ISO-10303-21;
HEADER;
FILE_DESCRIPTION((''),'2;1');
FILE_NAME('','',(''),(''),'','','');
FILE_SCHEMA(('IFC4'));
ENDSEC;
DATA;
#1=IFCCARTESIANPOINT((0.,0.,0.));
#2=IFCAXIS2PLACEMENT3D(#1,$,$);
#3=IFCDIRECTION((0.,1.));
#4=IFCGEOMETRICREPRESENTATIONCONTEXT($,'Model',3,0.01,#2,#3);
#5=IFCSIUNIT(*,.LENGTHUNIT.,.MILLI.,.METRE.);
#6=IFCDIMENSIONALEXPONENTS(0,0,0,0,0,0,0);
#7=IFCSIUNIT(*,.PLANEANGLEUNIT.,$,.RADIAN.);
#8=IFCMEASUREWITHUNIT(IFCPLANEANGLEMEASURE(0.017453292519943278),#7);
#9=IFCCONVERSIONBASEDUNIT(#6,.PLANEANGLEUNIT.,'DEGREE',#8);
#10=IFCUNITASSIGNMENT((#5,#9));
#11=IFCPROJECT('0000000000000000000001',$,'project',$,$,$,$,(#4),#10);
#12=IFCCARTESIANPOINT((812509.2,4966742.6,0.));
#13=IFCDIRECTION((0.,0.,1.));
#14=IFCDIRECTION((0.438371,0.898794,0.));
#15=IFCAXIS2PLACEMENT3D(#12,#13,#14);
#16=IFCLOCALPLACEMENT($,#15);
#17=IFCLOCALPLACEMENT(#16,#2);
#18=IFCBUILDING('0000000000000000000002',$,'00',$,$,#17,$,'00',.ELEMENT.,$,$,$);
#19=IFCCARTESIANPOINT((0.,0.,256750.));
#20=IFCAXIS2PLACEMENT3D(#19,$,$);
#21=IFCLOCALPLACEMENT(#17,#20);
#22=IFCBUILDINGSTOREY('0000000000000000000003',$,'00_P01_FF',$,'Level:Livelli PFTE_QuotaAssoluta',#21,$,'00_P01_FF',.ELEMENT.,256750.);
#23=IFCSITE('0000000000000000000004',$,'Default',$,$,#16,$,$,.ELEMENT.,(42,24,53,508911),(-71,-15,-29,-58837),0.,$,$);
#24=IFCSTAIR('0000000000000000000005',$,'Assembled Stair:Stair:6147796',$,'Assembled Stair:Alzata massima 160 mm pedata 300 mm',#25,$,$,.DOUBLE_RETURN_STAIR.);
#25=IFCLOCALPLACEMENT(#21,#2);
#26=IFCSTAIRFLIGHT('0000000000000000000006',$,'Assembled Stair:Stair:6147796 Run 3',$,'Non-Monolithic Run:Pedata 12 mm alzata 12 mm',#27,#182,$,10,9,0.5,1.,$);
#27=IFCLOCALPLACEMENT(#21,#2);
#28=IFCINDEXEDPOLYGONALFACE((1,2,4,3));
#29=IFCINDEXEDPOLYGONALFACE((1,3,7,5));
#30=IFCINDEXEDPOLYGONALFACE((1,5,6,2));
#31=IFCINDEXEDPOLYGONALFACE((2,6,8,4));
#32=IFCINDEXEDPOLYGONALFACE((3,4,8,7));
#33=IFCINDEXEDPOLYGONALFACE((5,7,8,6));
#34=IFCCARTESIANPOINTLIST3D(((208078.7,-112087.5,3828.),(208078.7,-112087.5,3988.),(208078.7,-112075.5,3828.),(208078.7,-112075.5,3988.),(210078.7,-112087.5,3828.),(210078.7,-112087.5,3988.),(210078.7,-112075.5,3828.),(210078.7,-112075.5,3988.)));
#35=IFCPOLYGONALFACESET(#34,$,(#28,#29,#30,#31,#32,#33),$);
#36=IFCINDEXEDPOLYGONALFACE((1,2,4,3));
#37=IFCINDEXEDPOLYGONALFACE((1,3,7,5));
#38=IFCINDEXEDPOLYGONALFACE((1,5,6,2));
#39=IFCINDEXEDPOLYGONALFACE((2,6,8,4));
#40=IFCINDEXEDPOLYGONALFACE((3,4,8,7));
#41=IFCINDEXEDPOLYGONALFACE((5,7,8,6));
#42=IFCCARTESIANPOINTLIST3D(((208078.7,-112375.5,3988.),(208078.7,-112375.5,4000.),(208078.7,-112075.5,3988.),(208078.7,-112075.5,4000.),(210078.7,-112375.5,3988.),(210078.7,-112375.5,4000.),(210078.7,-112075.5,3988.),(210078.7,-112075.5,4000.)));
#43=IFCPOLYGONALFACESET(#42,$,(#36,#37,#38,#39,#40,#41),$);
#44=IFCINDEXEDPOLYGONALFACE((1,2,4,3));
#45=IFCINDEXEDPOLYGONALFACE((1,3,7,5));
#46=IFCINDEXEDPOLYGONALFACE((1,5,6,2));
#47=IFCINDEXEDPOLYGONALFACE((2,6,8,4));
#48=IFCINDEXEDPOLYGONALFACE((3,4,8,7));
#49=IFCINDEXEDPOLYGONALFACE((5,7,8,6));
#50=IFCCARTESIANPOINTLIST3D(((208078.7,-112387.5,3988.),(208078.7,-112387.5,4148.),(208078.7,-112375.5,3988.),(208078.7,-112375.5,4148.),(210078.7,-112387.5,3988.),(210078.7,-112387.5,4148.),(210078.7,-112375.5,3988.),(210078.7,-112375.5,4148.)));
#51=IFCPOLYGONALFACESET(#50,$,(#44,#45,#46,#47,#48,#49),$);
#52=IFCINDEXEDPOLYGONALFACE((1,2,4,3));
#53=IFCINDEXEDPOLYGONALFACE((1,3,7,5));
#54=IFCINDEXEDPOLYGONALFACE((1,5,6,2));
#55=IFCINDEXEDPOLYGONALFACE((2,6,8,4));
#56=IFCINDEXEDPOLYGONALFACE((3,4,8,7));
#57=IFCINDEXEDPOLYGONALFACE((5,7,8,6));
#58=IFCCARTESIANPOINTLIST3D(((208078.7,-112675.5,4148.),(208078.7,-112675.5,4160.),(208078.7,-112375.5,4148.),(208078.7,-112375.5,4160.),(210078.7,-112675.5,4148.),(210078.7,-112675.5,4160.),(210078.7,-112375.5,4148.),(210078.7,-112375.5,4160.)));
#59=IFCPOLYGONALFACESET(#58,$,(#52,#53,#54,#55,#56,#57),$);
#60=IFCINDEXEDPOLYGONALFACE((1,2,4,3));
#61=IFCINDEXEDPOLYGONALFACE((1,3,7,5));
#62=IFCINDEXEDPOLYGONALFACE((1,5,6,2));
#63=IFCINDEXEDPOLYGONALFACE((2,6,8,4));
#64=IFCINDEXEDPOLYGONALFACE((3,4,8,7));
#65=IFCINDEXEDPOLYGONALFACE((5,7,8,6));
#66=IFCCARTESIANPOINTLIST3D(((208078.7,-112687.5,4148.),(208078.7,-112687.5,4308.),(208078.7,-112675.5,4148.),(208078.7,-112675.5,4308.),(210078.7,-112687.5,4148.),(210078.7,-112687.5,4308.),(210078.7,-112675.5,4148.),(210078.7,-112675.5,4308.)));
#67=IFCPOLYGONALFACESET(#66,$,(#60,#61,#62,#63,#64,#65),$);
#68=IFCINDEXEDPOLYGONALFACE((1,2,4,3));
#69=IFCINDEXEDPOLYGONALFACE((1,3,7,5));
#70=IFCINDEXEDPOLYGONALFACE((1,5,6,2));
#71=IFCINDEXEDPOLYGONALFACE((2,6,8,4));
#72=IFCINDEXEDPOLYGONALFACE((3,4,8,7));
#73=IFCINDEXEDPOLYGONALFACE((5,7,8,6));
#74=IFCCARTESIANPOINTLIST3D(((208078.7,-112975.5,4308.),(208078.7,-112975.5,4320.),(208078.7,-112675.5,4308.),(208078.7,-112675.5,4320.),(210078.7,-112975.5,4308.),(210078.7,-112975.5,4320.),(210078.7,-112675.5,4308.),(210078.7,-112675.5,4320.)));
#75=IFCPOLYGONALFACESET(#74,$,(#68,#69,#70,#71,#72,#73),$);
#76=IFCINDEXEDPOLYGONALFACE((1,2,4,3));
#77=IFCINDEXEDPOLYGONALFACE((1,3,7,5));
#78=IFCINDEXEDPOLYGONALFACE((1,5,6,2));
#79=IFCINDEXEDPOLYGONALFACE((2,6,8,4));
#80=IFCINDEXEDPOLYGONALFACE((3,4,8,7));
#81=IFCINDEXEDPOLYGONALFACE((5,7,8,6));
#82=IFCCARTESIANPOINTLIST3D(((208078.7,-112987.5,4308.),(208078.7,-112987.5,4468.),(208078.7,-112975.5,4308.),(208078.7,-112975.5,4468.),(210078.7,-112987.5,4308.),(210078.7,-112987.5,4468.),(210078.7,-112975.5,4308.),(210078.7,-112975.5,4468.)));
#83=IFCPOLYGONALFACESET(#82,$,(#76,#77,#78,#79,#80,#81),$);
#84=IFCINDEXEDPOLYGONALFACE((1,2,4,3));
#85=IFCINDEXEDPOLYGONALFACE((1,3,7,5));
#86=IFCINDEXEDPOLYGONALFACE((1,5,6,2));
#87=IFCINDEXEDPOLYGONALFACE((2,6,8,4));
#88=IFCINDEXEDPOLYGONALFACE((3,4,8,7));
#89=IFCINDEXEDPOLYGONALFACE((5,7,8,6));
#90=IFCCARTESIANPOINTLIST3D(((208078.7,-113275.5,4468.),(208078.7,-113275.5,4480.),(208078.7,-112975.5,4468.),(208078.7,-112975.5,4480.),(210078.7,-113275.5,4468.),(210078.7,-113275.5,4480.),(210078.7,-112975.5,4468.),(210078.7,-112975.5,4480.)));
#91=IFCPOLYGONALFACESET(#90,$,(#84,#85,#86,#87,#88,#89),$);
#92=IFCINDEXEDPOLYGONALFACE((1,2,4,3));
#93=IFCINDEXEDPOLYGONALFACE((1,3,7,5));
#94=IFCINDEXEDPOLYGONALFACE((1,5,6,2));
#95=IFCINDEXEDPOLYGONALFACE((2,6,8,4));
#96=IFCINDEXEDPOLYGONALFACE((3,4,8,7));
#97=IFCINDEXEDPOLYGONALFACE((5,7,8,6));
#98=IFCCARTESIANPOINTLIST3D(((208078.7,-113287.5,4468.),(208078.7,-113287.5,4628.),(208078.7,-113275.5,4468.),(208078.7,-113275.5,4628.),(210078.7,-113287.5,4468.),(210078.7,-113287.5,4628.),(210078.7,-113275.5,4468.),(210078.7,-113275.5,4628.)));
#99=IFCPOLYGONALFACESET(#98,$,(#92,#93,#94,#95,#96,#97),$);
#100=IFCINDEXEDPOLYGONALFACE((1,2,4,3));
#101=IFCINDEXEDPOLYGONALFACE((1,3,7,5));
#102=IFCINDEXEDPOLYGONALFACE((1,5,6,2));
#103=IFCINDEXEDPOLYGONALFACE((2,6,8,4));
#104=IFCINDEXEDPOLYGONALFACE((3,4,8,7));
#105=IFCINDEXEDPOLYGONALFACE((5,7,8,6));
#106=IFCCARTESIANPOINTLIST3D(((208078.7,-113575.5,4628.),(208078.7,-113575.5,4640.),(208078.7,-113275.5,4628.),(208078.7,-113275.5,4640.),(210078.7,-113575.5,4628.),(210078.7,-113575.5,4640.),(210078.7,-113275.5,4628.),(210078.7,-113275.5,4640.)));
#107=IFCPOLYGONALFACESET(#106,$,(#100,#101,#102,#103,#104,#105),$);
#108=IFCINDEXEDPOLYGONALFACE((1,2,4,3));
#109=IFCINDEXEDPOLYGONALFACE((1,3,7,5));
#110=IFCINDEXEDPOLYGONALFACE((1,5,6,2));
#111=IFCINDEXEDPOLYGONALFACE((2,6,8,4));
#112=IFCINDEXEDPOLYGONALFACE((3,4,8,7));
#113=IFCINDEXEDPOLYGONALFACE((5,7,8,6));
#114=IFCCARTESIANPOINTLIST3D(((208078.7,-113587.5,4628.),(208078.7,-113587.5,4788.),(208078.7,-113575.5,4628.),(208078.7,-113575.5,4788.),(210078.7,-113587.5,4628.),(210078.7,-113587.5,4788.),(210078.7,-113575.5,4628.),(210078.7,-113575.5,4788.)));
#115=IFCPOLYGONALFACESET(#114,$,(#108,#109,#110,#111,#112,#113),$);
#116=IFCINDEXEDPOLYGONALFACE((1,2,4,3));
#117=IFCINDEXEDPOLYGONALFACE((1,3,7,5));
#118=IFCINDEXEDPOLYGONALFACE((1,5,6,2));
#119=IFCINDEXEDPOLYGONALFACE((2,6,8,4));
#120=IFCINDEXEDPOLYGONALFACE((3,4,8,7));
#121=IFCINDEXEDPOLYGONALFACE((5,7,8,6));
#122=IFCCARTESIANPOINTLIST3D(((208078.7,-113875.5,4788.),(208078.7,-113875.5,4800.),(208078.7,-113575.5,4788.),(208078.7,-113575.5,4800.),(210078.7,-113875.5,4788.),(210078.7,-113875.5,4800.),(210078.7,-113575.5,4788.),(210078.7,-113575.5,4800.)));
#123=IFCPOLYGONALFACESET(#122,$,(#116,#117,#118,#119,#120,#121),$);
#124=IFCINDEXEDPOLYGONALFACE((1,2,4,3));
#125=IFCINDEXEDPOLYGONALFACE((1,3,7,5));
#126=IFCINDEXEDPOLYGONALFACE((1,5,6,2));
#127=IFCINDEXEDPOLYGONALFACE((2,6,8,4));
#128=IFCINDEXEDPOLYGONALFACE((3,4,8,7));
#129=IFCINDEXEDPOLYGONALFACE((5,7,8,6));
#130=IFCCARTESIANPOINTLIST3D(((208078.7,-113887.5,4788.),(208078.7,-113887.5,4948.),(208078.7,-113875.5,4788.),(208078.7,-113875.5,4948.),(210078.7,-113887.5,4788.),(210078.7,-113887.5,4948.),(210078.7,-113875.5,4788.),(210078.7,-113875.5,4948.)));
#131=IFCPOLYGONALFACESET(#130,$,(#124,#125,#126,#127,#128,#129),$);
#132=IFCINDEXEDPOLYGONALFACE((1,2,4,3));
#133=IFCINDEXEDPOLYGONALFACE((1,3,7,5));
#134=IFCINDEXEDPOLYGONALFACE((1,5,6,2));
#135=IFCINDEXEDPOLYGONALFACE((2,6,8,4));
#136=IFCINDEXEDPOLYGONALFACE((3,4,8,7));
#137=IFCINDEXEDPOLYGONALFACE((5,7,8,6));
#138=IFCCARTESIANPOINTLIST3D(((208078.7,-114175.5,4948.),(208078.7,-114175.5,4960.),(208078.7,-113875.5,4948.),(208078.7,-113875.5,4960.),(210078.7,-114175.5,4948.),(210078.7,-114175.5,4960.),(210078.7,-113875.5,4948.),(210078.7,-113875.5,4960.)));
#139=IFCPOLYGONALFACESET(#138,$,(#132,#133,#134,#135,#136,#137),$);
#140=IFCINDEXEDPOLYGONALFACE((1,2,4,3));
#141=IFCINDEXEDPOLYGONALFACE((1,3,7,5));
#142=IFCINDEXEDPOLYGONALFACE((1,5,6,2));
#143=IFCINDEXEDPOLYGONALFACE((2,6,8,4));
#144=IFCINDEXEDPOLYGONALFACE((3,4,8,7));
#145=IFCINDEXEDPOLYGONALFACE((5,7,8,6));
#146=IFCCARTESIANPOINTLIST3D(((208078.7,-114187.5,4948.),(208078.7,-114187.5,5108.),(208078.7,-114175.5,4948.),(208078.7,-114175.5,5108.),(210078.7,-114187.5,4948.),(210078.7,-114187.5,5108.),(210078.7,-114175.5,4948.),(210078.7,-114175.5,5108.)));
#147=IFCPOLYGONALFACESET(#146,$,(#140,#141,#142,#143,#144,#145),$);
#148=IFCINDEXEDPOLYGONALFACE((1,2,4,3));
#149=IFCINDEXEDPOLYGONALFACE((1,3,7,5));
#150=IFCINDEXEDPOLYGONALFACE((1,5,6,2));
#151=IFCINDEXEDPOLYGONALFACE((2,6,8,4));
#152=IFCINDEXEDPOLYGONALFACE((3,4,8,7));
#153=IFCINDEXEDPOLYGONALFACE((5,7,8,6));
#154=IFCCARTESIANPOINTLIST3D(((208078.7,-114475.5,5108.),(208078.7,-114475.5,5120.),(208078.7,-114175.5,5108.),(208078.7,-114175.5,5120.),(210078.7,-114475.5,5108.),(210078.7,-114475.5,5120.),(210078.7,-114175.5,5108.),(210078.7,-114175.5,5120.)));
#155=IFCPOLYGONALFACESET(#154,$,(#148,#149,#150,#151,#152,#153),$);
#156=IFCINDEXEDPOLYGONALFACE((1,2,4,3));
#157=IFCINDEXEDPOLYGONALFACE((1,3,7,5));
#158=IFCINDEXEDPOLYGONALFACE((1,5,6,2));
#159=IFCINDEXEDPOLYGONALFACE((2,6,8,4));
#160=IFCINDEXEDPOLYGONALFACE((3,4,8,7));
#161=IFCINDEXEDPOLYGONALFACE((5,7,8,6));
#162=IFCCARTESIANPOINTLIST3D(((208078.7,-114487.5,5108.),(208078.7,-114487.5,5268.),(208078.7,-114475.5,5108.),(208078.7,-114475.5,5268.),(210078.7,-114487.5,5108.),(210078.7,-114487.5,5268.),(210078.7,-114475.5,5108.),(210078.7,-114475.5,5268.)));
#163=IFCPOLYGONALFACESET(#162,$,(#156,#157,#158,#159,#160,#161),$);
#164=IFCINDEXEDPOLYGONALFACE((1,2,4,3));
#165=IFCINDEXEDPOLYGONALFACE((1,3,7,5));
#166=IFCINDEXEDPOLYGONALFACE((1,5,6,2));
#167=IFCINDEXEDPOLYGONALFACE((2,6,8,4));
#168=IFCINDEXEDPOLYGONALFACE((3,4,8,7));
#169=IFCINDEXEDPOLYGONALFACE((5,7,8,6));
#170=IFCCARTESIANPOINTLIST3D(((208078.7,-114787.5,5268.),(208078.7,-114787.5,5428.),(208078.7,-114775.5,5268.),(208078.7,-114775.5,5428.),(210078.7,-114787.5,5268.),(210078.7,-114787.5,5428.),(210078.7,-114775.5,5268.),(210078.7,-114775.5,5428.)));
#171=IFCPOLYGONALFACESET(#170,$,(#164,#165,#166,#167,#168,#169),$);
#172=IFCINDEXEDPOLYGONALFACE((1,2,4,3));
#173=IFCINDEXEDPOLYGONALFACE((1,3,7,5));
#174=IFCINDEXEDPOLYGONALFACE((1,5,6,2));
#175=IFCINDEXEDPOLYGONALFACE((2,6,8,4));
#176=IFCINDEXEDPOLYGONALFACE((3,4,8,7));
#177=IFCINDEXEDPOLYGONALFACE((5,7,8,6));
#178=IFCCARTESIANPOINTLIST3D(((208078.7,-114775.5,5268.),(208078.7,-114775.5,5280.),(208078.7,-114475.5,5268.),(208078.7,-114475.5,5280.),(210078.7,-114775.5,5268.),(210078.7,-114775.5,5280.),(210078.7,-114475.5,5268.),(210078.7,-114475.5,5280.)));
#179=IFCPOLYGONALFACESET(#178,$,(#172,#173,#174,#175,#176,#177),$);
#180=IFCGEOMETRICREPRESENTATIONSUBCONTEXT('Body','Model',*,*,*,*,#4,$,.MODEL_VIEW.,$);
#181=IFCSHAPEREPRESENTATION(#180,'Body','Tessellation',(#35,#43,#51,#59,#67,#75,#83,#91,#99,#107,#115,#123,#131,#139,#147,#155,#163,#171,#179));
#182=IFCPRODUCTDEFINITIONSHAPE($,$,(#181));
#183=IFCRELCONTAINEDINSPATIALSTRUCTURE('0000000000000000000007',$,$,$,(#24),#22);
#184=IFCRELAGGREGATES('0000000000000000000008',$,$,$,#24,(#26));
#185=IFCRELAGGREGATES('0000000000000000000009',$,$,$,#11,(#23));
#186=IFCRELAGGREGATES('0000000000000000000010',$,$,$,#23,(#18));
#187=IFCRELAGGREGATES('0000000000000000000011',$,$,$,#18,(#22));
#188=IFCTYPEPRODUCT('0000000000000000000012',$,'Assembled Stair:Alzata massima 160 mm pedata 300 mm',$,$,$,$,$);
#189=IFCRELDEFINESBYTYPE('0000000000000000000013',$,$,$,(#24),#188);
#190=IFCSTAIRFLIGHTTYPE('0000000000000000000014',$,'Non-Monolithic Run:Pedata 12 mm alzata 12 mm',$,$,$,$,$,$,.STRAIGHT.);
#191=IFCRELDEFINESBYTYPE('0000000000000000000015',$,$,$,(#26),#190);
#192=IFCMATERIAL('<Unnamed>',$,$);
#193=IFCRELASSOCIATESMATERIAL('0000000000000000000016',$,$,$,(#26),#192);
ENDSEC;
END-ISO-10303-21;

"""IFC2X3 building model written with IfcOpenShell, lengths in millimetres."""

from ifc_helpers import new_model, entity, si_unit, converted_unit, direction, frame, frame_2d, origin, origin_2d_with_axis, place, context, subcontext, project, spatial, rectangle, extrude, material, type_object, element, aggregate, save


model = new_model("IFC2X3")

# Units and contexts
model_context = context("Model", 3, precision=0.01, world=origin(), true_north=direction((0.0, 1.0)))
body_context = subcontext(model_context, "Body", "Model", "MODEL_VIEW")
ifc_project = project(units=[si_unit("LENGTHUNIT", "METRE", prefix="MILLI"), converted_unit("PLANEANGLEUNIT", "DEGREE", entity("IfcPlaneAngleMeasure", 0.017453292519943278), si_unit("PLANEANGLEUNIT", "RADIAN"), dimensions=[0, 0, 0, 0, 0, 0, 0])], contexts=[model_context])

# Site, building, storey
site_placement = place(None, frame((812509.2, 4966742.6, 0.0), z_axis=(0.0, 0.0, 1.0), x_axis=(0.438371, 0.898794, 0.0)))
site = spatial("IfcSite", under=ifc_project, at=site_placement, Name="Default", CompositionType="ELEMENT", RefLatitude=(42, 24, 53, 508911), RefLongitude=(-71, -15, -29, -58837), RefElevation=0.0)
building_placement = place(site_placement, origin())
building = spatial("IfcBuilding", under=site, at=building_placement, Name="00", LongName="00", CompositionType="ELEMENT")
storey_placement = place(building_placement, frame((0.0, 0.0, 256750.0)))
storey = spatial("IfcBuildingStorey", under=building, at=storey_placement, Name="00_P01_FF", ObjectType="Level:Livelli PFTE_QuotaAssoluta", LongName="00_P01_FF", CompositionType="ELEMENT", Elevation=256750.0)

# Stair
type_product = type_object("IfcTypeProduct", Name="Assembled Stair:Alzata massima 160 mm pedata 300 mm")
ifc_material = material(Name="<Unnamed>")
stair_1_placement = place(storey_placement, origin())
stair_1 = element("IfcStair", 1, at=stair_1_placement, inside=storey, type_object=type_product, Name="Assembled Stair:Stair:6147796", ObjectType="Assembled Stair:Alzata massima 160 mm pedata 300 mm", ShapeType="DOUBLE_RETURN_STAIR")

# Stair flight
stair_flight_type = type_object("IfcStairFlightType", Name="Non-Monolithic Run:Pedata 12 mm alzata 12 mm", PredefinedType="STRAIGHT")
stair_flight_1_placement = place(stair_1_placement, origin())
stair_flight_1 = element("IfcStairFlight", 2, at=stair_flight_1_placement, type_object=stair_flight_type, material=ifc_material, Name="Assembled Stair:Stair:6147796 Run 3", ObjectType="Non-Monolithic Run:Pedata 12 mm alzata 12 mm", NumberOfRiser=10, NumberOfTreads=9, RiserHeight=0.5, TreadLength=1.0, context=body_context, shape_type="SweptSolid", body=[
    extrude(rectangle(XDim=2000.0, YDim=12.0, at=origin_2d_with_axis()), frame((209078.7, -112081.5, 3828.0)), (0.0, 0.0, 1.0), 160.0),
    extrude(rectangle(XDim=300.0, YDim=2000.0, at=origin_2d_with_axis()), frame((209078.7, -112225.5, 3988.0), z_axis=(0.0, 0.0, 1.0), x_axis=(0.0, 1.0, 0.0)), (0.0, 0.0, 1.0), 12.0),
    extrude(rectangle(XDim=2000.0, YDim=12.0, at=origin_2d_with_axis()), frame((209078.7, -112381.5, 3988.0)), (0.0, 0.0, 1.0), 160.0),
    extrude(rectangle(XDim=300.0, YDim=2000.0, at=frame_2d((0.0, 0.0), x_axis=(1.0, 0.0))), frame((209078.7, -112525.5, 4148.0), z_axis=(0.0, 0.0, 1.0), x_axis=(0.0, 1.0, 0.0)), (0.0, 0.0, 1.0), 12.0),
    extrude(rectangle(XDim=2000.0, YDim=12.0, at=frame_2d((0.0, 0.0), x_axis=(1.0, 0.0))), frame((209078.7, -112681.5, 4148.0)), (0.0, 0.0, 1.0), 160.0),
    extrude(rectangle(XDim=300.0, YDim=2000.0, at=frame_2d((0.0, 0.0), x_axis=(1.0, 0.0))), frame((209078.7, -112825.5, 4308.0), z_axis=(0.0, 0.0, 1.0), x_axis=(0.0, 1.0, 0.0)), (0.0, 0.0, 1.0), 12.0),
    extrude(rectangle(XDim=2000.0, YDim=12.0, at=frame_2d((0.0, 0.0), x_axis=(1.0, 0.0))), frame((209078.7, -112981.5, 4308.0)), (0.0, 0.0, 1.0), 160.0),
    extrude(rectangle(XDim=300.0, YDim=2000.0, at=frame_2d((0.0, 0.0), x_axis=(1.0, 0.0))), frame((209078.7, -113125.5, 4468.0), z_axis=(0.0, 0.0, 1.0), x_axis=(0.0, 1.0, 0.0)), (0.0, 0.0, 1.0), 12.0),
    extrude(rectangle(XDim=2000.0, YDim=12.0, at=frame_2d((0.0, 0.0), x_axis=(1.0, 0.0))), frame((209078.7, -113281.5, 4468.0)), (0.0, 0.0, 1.0), 160.0),
    extrude(rectangle(XDim=300.0, YDim=2000.0, at=frame_2d((0.0, 0.0), x_axis=(1.0, 0.0))), frame((209078.7, -113425.5, 4628.0), z_axis=(0.0, 0.0, 1.0), x_axis=(0.0, 1.0, 0.0)), (0.0, 0.0, 1.0), 12.0),
    extrude(rectangle(XDim=2000.0, YDim=12.0, at=frame_2d((0.0, 0.0), x_axis=(1.0, 0.0))), frame((209078.7, -113581.5, 4628.0)), (0.0, 0.0, 1.0), 160.0),
    extrude(rectangle(XDim=300.0, YDim=2000.0, at=frame_2d((0.0, 0.0), x_axis=(1.0, 0.0))), frame((209078.7, -113725.5, 4788.0), z_axis=(0.0, 0.0, 1.0), x_axis=(0.0, 1.0, 0.0)), (0.0, 0.0, 1.0), 12.0),
    extrude(rectangle(XDim=2000.0, YDim=12.0, at=origin_2d_with_axis()), frame((209078.7, -113881.5, 4788.0)), (0.0, 0.0, 1.0), 160.0),
    extrude(rectangle(XDim=300.0, YDim=2000.0, at=frame_2d((0.0, 0.0), x_axis=(1.0, 0.0))), frame((209078.7, -114025.5, 4948.0), z_axis=(0.0, 0.0, 1.0), x_axis=(0.0, 1.0, 0.0)), (0.0, 0.0, 1.0), 12.0),
    extrude(rectangle(XDim=2000.0, YDim=12.0, at=origin_2d_with_axis()), frame((209078.7, -114181.5, 4948.0)), (0.0, 0.0, 1.0), 160.0),
    extrude(rectangle(XDim=300.0, YDim=2000.0, at=frame_2d((0.0, 0.0), x_axis=(1.0, 0.0))), frame((209078.7, -114325.5, 5108.0), z_axis=(0.0, 0.0, 1.0), x_axis=(0.0, 1.0, 0.0)), (0.0, 0.0, 1.0), 12.0),
    extrude(rectangle(XDim=2000.0, YDim=12.0, at=origin_2d_with_axis()), frame((209078.7, -114481.5, 5108.0)), (0.0, 0.0, 1.0), 160.0),
    extrude(rectangle(XDim=2000.0, YDim=12.0, at=origin_2d_with_axis()), frame((209078.7, -114781.5, 5268.0)), (0.0, 0.0, 1.0), 160.0),
    extrude(rectangle(XDim=300.0, YDim=2000.0, at=frame_2d((0.0, 0.0), x_axis=(1.0, 0.0))), frame((209078.7, -114625.5, 5268.0), z_axis=(0.0, 0.0, 1.0), x_axis=(0.0, 1.0, 0.0)), (0.0, 0.0, 1.0), 12.0),
])
aggregate(stair_1, [stair_flight_1])

save(model, "model.ifc")
